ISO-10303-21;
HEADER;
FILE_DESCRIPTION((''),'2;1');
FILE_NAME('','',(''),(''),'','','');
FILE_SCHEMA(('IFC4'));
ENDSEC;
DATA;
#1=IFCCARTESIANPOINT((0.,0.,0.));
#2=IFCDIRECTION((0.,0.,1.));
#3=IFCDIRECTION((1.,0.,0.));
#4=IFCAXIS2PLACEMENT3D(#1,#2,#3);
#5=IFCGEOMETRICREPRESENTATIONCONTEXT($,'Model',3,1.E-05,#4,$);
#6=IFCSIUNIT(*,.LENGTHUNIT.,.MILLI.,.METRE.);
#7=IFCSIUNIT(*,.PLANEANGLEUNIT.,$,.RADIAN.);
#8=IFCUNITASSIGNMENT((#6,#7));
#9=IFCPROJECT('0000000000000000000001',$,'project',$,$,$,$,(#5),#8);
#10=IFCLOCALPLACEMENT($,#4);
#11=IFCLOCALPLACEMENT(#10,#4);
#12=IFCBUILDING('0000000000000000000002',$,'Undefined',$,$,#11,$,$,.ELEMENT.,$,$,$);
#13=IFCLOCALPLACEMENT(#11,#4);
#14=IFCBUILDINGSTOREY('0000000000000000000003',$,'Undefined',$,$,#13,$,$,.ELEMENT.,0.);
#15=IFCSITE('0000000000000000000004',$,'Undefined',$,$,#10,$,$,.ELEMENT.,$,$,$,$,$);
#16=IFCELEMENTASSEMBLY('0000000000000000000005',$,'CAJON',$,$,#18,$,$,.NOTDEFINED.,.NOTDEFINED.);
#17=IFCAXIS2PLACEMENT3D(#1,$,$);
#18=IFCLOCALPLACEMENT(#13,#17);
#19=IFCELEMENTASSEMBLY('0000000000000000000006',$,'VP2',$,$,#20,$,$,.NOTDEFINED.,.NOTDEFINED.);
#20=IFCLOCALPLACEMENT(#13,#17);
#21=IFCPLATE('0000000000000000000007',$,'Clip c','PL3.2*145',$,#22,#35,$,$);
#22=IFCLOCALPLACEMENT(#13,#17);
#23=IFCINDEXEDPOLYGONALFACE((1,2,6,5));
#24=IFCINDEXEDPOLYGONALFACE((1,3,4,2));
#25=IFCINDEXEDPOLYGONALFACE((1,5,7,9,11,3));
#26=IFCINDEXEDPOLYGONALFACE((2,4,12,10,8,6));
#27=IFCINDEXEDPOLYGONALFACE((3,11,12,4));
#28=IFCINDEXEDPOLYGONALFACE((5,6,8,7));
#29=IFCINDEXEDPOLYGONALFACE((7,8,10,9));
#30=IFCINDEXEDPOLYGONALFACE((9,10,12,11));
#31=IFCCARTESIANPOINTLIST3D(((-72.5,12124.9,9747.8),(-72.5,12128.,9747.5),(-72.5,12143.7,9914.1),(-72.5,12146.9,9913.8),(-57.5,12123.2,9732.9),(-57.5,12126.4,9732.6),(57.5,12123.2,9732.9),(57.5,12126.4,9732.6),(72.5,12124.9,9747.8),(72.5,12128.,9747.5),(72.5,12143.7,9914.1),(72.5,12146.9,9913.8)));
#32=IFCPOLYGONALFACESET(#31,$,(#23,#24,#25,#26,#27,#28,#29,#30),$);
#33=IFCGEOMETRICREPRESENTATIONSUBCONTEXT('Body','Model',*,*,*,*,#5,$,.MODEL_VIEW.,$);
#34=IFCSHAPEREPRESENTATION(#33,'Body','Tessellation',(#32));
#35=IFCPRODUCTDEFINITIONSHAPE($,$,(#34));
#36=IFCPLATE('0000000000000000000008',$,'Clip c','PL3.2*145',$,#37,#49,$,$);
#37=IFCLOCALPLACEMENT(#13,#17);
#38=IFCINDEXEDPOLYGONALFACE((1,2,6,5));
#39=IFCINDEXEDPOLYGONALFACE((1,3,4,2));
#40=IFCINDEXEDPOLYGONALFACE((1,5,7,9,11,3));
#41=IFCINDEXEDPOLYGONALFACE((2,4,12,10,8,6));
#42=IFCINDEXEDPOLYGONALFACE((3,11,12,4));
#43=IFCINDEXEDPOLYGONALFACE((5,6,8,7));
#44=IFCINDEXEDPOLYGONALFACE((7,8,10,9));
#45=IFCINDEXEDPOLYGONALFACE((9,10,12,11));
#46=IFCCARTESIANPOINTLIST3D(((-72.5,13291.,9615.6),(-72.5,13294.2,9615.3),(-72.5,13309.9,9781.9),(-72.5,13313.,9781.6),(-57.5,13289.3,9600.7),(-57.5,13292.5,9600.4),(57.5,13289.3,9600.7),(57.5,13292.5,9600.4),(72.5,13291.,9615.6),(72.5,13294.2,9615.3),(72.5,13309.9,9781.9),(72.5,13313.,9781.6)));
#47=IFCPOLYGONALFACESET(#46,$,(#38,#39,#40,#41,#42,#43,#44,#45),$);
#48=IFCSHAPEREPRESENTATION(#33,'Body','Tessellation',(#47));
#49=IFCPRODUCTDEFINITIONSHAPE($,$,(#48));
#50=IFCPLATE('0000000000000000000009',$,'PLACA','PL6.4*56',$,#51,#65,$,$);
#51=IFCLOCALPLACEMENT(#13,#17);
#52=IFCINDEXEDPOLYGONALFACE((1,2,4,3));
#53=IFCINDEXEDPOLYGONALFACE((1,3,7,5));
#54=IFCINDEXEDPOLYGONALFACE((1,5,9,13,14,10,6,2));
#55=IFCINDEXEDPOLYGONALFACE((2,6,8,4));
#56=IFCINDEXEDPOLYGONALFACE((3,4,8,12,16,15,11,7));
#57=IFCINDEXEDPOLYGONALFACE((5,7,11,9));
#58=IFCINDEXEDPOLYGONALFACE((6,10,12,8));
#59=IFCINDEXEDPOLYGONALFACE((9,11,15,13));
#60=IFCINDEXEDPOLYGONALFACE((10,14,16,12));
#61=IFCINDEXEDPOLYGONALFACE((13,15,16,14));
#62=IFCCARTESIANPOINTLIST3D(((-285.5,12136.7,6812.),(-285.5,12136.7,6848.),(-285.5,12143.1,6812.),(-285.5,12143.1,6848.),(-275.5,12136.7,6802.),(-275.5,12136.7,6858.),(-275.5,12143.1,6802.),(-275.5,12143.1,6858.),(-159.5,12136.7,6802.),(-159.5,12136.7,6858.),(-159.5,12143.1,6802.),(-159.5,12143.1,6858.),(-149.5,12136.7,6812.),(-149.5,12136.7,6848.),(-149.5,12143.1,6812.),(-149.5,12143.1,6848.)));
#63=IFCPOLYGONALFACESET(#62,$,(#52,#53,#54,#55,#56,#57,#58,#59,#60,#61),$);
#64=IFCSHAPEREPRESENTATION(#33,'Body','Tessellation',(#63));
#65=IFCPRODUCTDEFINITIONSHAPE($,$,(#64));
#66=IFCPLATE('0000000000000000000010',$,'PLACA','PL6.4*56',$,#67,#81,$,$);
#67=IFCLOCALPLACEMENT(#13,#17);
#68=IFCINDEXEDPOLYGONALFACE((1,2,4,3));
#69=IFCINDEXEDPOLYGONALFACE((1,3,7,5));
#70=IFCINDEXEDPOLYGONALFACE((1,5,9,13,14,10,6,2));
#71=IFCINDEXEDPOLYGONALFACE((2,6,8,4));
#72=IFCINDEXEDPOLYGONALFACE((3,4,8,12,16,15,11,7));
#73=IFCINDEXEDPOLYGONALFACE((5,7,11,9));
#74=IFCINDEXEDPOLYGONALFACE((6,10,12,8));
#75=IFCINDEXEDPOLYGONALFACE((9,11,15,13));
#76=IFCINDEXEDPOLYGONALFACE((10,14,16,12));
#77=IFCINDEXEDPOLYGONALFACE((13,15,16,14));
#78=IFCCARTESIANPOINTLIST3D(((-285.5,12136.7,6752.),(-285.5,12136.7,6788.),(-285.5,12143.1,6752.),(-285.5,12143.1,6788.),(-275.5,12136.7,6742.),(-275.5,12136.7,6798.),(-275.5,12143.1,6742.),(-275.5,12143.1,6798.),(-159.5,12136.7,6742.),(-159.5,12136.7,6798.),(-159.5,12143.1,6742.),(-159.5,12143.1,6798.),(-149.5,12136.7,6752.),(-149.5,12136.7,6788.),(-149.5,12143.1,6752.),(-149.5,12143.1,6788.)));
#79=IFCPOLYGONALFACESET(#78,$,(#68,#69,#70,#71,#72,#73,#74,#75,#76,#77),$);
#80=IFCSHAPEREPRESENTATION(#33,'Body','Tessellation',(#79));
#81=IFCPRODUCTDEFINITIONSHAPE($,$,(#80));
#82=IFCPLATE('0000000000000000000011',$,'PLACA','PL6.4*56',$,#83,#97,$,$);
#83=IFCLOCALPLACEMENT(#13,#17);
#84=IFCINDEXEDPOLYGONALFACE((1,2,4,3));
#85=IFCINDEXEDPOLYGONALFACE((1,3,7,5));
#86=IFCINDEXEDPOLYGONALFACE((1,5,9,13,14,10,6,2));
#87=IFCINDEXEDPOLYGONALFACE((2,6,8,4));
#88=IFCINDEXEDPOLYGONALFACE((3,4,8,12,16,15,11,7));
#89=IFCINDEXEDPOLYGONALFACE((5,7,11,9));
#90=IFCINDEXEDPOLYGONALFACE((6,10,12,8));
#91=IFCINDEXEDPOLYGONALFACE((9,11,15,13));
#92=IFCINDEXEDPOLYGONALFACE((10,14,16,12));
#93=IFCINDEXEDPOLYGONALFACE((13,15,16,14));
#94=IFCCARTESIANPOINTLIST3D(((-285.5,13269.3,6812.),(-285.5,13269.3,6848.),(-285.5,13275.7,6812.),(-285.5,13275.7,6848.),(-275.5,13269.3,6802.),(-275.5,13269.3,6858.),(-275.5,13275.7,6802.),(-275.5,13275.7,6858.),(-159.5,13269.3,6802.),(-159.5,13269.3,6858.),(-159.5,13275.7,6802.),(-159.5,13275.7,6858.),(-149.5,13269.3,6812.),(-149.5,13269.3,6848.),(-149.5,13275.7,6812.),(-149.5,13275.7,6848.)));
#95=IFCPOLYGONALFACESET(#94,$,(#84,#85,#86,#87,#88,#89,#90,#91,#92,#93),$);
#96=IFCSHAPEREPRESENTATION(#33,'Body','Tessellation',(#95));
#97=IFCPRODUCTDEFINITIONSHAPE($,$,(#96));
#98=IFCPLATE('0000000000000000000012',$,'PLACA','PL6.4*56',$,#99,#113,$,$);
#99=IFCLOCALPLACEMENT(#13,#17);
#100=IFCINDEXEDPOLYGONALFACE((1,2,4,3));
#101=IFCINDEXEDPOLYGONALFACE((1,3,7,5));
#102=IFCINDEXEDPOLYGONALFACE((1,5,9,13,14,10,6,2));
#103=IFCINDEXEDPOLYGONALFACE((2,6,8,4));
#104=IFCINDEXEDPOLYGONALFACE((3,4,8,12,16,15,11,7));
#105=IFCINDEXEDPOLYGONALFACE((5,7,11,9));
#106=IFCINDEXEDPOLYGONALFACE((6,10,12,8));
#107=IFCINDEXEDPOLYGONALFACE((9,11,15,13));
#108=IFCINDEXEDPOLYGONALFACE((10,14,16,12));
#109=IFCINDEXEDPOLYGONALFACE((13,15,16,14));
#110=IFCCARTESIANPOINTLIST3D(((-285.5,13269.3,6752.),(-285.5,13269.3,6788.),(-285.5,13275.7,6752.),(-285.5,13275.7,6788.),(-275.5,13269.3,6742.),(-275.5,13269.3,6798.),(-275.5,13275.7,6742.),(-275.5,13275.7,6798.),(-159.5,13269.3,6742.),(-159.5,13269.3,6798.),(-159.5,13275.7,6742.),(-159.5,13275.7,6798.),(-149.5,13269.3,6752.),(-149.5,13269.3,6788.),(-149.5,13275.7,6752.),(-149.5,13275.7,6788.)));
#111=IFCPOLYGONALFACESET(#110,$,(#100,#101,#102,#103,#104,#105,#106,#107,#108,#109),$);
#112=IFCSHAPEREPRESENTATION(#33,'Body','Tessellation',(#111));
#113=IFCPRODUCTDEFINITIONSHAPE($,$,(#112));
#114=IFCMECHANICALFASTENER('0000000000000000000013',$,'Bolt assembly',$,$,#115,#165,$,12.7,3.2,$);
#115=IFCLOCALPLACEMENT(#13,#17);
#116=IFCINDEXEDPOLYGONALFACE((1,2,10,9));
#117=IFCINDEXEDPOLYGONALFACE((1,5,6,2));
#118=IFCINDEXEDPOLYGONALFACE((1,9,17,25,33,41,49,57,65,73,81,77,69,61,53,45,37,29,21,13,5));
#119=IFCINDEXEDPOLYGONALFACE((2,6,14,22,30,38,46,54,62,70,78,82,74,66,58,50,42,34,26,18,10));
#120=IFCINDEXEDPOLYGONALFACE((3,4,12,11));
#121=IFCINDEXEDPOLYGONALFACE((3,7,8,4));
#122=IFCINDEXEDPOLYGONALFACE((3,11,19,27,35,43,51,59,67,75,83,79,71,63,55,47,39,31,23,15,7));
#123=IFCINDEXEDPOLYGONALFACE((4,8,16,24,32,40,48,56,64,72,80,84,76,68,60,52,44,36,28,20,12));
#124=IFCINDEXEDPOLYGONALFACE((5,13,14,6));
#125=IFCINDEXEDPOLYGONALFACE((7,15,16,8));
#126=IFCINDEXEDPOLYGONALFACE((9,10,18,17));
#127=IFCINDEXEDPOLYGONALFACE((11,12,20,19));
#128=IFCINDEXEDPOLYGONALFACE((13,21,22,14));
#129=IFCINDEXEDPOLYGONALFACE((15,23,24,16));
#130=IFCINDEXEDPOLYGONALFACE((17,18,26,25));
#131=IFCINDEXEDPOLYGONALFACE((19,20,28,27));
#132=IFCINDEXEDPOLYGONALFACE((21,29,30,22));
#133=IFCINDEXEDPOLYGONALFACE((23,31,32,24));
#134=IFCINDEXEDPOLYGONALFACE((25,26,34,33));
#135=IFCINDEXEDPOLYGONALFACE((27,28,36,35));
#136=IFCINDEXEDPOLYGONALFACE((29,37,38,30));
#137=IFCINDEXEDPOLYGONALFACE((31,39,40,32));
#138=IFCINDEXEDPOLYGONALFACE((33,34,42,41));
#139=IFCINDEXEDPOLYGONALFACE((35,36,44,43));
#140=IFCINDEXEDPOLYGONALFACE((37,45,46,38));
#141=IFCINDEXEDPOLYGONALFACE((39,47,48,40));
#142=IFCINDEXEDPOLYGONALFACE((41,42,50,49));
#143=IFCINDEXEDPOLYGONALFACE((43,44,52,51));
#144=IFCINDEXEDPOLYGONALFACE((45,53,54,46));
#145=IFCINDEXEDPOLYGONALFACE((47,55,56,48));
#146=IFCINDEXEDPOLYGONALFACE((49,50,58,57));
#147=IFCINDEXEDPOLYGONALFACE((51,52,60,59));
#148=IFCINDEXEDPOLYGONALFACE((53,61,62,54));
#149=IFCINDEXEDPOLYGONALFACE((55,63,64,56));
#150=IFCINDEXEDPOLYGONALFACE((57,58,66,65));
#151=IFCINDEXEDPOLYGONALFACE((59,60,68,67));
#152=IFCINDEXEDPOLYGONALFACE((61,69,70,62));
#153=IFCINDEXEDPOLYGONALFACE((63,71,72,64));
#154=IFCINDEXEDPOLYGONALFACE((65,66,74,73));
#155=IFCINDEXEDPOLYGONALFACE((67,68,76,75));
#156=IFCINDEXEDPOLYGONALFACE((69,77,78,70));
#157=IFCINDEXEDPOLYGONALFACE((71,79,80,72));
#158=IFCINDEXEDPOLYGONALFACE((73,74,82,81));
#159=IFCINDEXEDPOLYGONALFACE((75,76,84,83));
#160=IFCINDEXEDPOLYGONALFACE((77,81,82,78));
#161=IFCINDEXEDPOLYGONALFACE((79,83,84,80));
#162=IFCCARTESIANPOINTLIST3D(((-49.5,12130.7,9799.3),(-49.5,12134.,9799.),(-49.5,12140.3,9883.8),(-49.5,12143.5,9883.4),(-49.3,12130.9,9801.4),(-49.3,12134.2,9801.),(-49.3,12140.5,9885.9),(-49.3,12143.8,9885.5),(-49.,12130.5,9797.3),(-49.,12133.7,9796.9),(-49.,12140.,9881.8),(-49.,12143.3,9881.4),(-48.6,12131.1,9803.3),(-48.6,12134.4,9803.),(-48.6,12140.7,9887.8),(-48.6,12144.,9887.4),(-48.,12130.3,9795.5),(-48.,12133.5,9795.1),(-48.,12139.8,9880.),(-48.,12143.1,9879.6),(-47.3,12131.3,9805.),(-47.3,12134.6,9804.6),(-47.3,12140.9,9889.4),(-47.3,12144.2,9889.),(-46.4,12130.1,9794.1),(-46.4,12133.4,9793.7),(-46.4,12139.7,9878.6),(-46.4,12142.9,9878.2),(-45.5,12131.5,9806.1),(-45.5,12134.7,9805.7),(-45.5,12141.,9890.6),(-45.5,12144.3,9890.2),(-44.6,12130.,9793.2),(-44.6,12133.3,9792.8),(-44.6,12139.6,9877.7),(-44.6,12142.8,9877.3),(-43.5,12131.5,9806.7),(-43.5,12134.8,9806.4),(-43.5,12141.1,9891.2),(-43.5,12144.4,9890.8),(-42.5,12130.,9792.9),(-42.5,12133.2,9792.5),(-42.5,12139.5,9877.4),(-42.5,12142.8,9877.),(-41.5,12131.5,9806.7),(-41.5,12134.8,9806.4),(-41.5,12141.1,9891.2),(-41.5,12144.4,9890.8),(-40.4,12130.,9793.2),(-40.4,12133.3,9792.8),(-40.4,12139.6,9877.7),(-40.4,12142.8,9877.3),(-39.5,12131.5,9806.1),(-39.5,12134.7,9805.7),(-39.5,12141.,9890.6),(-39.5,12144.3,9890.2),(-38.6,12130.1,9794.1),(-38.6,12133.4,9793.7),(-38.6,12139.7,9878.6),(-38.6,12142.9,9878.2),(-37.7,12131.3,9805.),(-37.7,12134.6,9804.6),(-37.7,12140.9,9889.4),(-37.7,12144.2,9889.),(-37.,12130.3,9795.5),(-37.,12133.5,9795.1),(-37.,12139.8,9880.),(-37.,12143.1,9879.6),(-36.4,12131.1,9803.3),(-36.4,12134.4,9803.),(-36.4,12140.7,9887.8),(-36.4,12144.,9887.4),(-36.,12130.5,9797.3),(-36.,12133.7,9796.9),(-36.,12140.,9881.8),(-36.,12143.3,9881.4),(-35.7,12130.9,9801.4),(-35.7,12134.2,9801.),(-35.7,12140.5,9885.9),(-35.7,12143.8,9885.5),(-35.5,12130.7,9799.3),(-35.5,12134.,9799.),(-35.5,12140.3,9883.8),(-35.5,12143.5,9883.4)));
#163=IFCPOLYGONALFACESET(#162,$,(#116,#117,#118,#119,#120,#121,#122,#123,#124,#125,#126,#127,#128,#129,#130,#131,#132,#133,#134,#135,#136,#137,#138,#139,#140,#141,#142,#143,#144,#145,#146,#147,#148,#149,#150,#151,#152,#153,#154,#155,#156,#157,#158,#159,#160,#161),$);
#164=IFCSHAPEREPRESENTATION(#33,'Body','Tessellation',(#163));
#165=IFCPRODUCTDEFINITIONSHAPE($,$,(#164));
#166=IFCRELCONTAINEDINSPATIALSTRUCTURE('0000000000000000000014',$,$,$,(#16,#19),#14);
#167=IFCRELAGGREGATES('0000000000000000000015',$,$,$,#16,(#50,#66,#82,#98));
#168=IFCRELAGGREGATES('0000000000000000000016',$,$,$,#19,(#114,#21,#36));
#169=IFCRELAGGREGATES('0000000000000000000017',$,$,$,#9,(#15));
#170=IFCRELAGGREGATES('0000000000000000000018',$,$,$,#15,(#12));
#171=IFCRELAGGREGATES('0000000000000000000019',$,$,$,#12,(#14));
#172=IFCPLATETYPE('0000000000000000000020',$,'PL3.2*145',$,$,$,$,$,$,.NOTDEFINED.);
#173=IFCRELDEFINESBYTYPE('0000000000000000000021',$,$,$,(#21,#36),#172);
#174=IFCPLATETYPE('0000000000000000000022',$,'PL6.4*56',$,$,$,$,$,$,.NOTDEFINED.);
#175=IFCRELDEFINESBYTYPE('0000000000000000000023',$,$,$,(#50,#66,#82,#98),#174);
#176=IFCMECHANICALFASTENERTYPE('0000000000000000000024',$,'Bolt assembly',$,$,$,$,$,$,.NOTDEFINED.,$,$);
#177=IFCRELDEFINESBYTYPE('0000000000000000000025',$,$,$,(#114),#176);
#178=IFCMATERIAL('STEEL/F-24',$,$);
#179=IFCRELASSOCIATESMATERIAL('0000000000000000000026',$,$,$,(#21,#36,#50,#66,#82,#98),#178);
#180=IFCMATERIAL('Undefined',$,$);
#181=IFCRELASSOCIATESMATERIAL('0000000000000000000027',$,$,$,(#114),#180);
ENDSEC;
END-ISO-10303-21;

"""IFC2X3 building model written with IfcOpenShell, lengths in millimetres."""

from ifc_helpers import new_model, si_unit, frame, origin_with_axes, origin_2d_with_axis, place, context, subcontext, project, spatial, polyline, circle, outline, extrude, source, transform, mapped, material, type_object, element, aggregate, save


model = new_model("IFC2X3")

# Units and contexts
model_context = context("Model", 3, precision=1e-05, world=origin_with_axes())
body_context = subcontext(model_context, "Body", "Model", "MODEL_VIEW")
ifc_project = project(units=[si_unit("LENGTHUNIT", "METRE", prefix="MILLI"), si_unit("PLANEANGLEUNIT", "RADIAN")], contexts=[model_context])

# Site, building, storey
site_placement = place(None, origin_with_axes())
site = spatial("IfcSite", under=ifc_project, at=site_placement, Name="Undefined", CompositionType="ELEMENT")
building_placement = place(site_placement, origin_with_axes())
building = spatial("IfcBuilding", under=site, at=building_placement, Name="Undefined", CompositionType="ELEMENT")
storey_placement = place(building_placement, origin_with_axes())
storey = spatial("IfcBuildingStorey", under=building, at=storey_placement, Name="Undefined", CompositionType="ELEMENT", Elevation=0.0)

# Shared definitions
ifc_material_1 = material(Name="STEEL/F-24")

# Element assemblies, plates
assembly_1_placement = place(storey_placement, origin_with_axes())
assembly_1 = element("IfcElementAssembly", 1, at=assembly_1_placement, inside=storey, Name="CAJON", AssemblyPlace="NOTDEFINED", PredefinedType="NOTDEFINED")
assembly_2_placement = place(storey_placement, origin_with_axes())
assembly_2 = element("IfcElementAssembly", 2, at=assembly_2_placement, inside=storey, Name="VP2", AssemblyPlace="NOTDEFINED", PredefinedType="NOTDEFINED")
plate_type_1 = type_object("IfcPlateType", Name="PL3.2*145", PredefinedType="NOTDEFINED")
plate_1_placement = place(assembly_2_placement, frame((72.5, 12124.8, 9732.8), z_axis=(0.0, -0.993645, 0.112559), x_axis=(0.0, 0.112559, 0.993645)))
plate_1 = element("IfcPlate", 3, at=plate_1_placement, type_object=plate_type_1, material=ifc_material_1, Name="Clip c", Description="PL3.2*145", context=body_context, shape_type="SweptSolid", body=[
    extrude(outline(polyline([(0.0, 15.0), (15.0, 0.0), (182.3, 0.0), (182.3, 145.0), (15.0, 145.0), (0.0, 130.0), (0.0, 15.0)])), frame((0.0, 0.0, -1.6), z_axis=(0.0, 0.0, 1.0), x_axis=(1.0, 0.0, 0.0)), (0.0, 0.0, 1.0), 3.2),
])
plate_2_placement = place(assembly_2_placement, frame((72.5, 13290.9, 9600.6), z_axis=(0.0, -0.993645, 0.112559), x_axis=(0.0, 0.112559, 0.993645)))
plate_2 = element("IfcPlate", 4, at=plate_2_placement, type_object=plate_type_1, material=ifc_material_1, Name="Clip c", Description="PL3.2*145", context=body_context, shape_type="SweptSolid", body=[
    extrude(outline(polyline([(0.0, 15.0), (15.0, 0.0), (182.3, 0.0), (182.3, 145.0), (15.0, 145.0), (0.0, 130.0), (0.0, 15.0)])), frame((0.0, 0.0, -1.6), z_axis=(0.0, 0.0, 1.0), x_axis=(1.0, 0.0, 0.0)), (0.0, 0.0, 1.0), 3.2),
])

# Plates
plate_type_2 = type_object("IfcPlateType", Name="PL6.4*56", PredefinedType="NOTDEFINED")
plate_3_placement = place(assembly_1_placement, frame((-149.5, 12139.9, 6802.0), z_axis=(0.0, -1.0, 0.000002), x_axis=(0.0, 0.000002, 1.0)))
plate_3 = element("IfcPlate", 5, at=plate_3_placement, type_object=plate_type_2, material=ifc_material_1, Name="PLACA", Description="PL6.4*56", context=body_context, shape_type="SweptSolid", body=[
    extrude(outline(polyline([(0.0, 10.0), (10.0, 0.0), (46.0, 0.0), (56.0, 10.0), (56.0, 126.0), (46.0, 136.0), (10.0, 136.0), (0.0, 126.0), (0.0, 10.0)])), frame((0.0, 0.0, -3.2), z_axis=(0.0, 0.0, 1.0), x_axis=(1.0, 0.0, 0.0)), (0.0, 0.0, 1.0), 6.4),
])
plate_4_placement = place(assembly_1_placement, frame((-149.5, 12139.9, 6798.0), z_axis=(0.0, 1.0, -0.000002), x_axis=(0.0, -0.000002, -1.0)))
plate_4 = element("IfcPlate", 6, at=plate_4_placement, type_object=plate_type_2, material=ifc_material_1, Name="PLACA", Description="PL6.4*56", context=body_context, shape_type="SweptSolid", body=[
    extrude(outline(polyline([(0.0, 10.0), (10.0, 0.0), (46.0, 0.0), (56.0, 10.0), (56.0, 126.0), (46.0, 136.0), (10.0, 136.0), (0.0, 126.0), (0.0, 10.0)])), frame((0.0, 0.0, -3.2), z_axis=(0.0, 0.0, 1.0), x_axis=(1.0, 0.0, 0.0)), (0.0, 0.0, 1.0), 6.4),
])
plate_5_placement = place(assembly_1_placement, frame((-149.5, 13272.5, 6802.0), z_axis=(0.0, -1.0, 0.000002), x_axis=(0.0, 0.000002, 1.0)))
plate_5 = element("IfcPlate", 7, at=plate_5_placement, type_object=plate_type_2, material=ifc_material_1, Name="PLACA", Description="PL6.4*56", context=body_context, shape_type="SweptSolid", body=[
    extrude(outline(polyline([(0.0, 10.0), (10.0, 0.0), (46.0, 0.0), (56.0, 10.0), (56.0, 126.0), (46.0, 136.0), (10.0, 136.0), (0.0, 126.0), (0.0, 10.0)])), frame((0.0, 0.0, -3.2), z_axis=(0.0, 0.0, 1.0), x_axis=(1.0, 0.0, 0.0)), (0.0, 0.0, 1.0), 6.4),
])
plate_6_placement = place(assembly_1_placement, frame((-149.5, 13272.5, 6798.0), z_axis=(0.0, 1.0, -0.000002), x_axis=(0.0, -0.000002, -1.0)))
plate_6 = element("IfcPlate", 8, at=plate_6_placement, type_object=plate_type_2, material=ifc_material_1, Name="PLACA", Description="PL6.4*56", context=body_context, shape_type="SweptSolid", body=[
    extrude(outline(polyline([(0.0, 10.0), (10.0, 0.0), (46.0, 0.0), (56.0, 10.0), (56.0, 126.0), (46.0, 136.0), (10.0, 136.0), (0.0, 126.0), (0.0, 10.0)])), frame((0.0, 0.0, -3.2), z_axis=(0.0, 0.0, 1.0), x_axis=(1.0, 0.0, 0.0)), (0.0, 0.0, 1.0), 6.4),
])

# Shared definitions
ifc_material_2 = material(Name="Undefined")
mechanical_fastener_type = type_object("IfcMechanicalFastenerType", Name="Bolt assembly")
aggregate(assembly_1, [plate_3, plate_4, plate_5, plate_6])

# Mechanical fastener
shared_shape_1 = source(origin_with_axes(), body_context, "Body", "SweptSolid", [
    extrude(circle(Radius=7.0, at=origin_2d_with_axis()), frame((0.0, -3.2, 0.0), z_axis=(0.0, 1.0, 0.0), x_axis=(1.0, 0.0, 0.0)), (0.0, 0.0, 1.0), 3.3),
])
mechanical_fastener_1_placement = place(assembly_2_placement, frame((-42.5, 12143.5, 9884.0), z_axis=(1.0, 0.0, 0.0), x_axis=(0.0, -0.112644, -0.993635)))
mechanical_fastener_1 = element("IfcMechanicalFastener", 9, at=mechanical_fastener_1_placement, type_object=mechanical_fastener_type, material=ifc_material_2, Name="Bolt assembly", NominalDiameter=12.7, NominalLength=3.2, context=body_context, shape_type="MappedRepresentation", body=[
    mapped(shared_shape_1, transform((0.0, 0.0, 0.0))),
    mapped(shared_shape_1, transform((85.0, 0.0, 0.0))),
])
aggregate(assembly_2, [mechanical_fastener_1, plate_1, plate_2])

save(model, "model.ifc")
